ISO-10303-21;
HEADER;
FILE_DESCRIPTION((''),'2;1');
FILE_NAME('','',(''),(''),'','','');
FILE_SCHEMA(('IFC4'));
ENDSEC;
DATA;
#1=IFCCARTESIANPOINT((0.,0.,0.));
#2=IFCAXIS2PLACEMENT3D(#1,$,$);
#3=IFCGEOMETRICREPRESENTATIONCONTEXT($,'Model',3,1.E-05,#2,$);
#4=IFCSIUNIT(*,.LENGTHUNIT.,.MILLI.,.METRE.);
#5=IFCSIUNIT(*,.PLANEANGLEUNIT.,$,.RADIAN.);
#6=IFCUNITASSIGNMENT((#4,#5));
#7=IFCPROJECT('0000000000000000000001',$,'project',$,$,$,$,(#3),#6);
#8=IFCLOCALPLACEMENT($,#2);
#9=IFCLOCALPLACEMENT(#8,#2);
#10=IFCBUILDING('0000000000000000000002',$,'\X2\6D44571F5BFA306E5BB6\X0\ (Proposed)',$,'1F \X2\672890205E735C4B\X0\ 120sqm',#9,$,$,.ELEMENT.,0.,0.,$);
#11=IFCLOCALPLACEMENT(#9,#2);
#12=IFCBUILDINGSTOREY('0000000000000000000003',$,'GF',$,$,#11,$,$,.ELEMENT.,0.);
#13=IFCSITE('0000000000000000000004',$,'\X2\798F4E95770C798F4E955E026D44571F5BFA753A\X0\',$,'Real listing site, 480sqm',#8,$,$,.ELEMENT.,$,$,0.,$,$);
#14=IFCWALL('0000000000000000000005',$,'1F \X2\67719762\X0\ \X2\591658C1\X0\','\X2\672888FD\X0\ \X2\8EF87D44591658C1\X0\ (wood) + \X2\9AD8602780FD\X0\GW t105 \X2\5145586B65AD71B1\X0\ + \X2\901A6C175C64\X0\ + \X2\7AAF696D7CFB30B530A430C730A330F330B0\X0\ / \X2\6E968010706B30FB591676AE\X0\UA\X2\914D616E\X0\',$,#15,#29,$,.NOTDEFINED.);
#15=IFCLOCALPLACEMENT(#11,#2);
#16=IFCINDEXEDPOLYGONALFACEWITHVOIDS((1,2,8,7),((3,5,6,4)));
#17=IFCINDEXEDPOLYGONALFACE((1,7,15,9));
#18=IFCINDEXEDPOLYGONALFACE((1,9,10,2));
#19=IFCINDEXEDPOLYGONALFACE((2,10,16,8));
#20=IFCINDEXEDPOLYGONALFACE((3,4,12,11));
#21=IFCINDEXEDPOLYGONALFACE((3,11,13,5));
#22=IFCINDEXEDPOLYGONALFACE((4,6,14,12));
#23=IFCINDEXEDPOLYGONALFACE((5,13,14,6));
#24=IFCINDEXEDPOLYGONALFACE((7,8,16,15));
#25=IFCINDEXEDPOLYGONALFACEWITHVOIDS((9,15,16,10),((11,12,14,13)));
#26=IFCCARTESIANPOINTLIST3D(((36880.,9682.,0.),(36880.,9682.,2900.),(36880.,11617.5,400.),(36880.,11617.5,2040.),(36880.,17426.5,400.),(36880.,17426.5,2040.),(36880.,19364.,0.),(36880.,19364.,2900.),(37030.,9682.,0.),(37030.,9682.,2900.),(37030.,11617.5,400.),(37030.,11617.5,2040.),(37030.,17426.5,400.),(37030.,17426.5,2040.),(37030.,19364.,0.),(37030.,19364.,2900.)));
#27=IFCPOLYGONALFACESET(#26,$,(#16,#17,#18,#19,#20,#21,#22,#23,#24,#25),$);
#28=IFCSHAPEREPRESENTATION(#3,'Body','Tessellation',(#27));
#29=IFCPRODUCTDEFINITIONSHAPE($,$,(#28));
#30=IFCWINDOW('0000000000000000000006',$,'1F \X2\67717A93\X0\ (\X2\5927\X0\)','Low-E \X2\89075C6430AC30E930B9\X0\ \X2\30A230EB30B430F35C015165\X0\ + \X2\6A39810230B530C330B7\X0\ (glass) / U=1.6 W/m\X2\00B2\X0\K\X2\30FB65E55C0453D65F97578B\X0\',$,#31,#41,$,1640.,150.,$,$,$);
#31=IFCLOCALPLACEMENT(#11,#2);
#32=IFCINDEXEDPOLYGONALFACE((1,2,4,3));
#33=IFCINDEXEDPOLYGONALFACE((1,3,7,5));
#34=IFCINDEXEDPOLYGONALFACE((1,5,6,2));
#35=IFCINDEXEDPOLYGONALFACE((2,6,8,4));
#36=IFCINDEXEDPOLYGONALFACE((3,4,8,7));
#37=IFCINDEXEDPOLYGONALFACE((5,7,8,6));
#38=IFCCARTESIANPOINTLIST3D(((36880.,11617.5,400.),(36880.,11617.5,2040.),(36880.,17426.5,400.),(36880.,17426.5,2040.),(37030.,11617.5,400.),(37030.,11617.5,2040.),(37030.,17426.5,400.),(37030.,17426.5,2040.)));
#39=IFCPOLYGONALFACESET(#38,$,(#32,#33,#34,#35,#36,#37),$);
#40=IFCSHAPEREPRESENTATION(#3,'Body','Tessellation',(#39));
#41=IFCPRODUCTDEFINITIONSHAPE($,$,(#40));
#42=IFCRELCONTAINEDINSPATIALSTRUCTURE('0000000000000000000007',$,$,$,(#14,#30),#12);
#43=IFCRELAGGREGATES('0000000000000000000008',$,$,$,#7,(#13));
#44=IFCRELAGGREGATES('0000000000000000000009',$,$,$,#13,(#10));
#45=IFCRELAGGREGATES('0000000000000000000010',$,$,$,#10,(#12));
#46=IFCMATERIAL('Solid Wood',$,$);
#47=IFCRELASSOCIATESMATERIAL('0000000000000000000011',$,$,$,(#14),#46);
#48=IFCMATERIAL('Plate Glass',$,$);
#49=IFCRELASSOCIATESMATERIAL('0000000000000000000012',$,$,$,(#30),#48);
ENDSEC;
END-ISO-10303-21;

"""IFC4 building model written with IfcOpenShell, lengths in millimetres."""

from ifc_helpers import new_model, si_unit, frame, frame_2d, origin, place, context, project, spatial, rectangle, extrude, material, element, fill, save


model = new_model("IFC4")

# Units and contexts
model_context = context("Model", 3, precision=1e-05, world=origin())
ifc_project = project(units=[si_unit("LENGTHUNIT", "METRE", prefix="MILLI"), si_unit("PLANEANGLEUNIT", "RADIAN")], contexts=[model_context])

# Site, building, storey
site_placement = place(None, origin())
site = spatial("IfcSite", under=ifc_project, at=site_placement, Name="福井県福井市浄土寺町", ObjectType="Real listing site, 480sqm", CompositionType="ELEMENT", RefElevation=0.0)
building_placement = place(site_placement, origin())
building = spatial("IfcBuilding", under=site, at=building_placement, Name="浄土寺の家 (Proposed)", ObjectType="1F 木造平屋 120sqm", CompositionType="ELEMENT", ElevationOfRefHeight=0.0, ElevationOfTerrain=0.0)
storey_placement = place(building_placement, origin())
storey = spatial("IfcBuildingStorey", under=building, at=storey_placement, Name="GF", CompositionType="ELEMENT", Elevation=0.0)

# Shared definitions
ifc_material_1 = material(Name="Solid Wood")

# Wall, opening, window
wall_1_placement = place(storey_placement, frame((18440.0, 4841.0, 0.0)))
wall_1 = element("IfcWall", 1, at=wall_1_placement, inside=storey, material=ifc_material_1, Name="1F 東面 外壁", Description="木製 軸組外壁 (wood) + 高性能GW t105 充填断熱 + 通気層 + 窯業系サイディング / 準耐火・外皮UA配慮", PredefinedType="NOTDEFINED", context=model_context, shape_type="SweptSolid", body=[
    extrude(rectangle(XDim=150.0, YDim=9682.0, at=frame_2d((75.0, 4841.0))), frame((18440.0, 4841.0, 0.0)), (0.0, 0.0, 1.0), 2900.0),
])
opening_placement = place(storey_placement, frame((18440.0, 5809.0, 200.0)))
opening = element("IfcOpeningElement", 2, at=opening_placement, cuts=wall_1, PredefinedType="NOTDEFINED", context=model_context, shape_type="SweptSolid", body=[
    extrude(rectangle(XDim=150.0, YDim=5809.0, at=frame_2d((75.0, 2904.0))), frame((18440.0, 5809.0, 200.0)), (0.0, 0.0, 1.0), 1640.0),
])
ifc_material_2 = material(Name="Plate Glass")
window_placement = place(storey_placement, frame((18440.0, 5809.0, 200.0)))
window = element("IfcWindow", 3, at=window_placement, inside=storey, material=ifc_material_2, Name="1F 東窓 (大)", Description="Low-E 複層ガラス アルゴン封入 + 樹脂サッシ (glass) / U=1.6 W/m²K・日射取得型", OverallHeight=1640.0, OverallWidth=150.0, context=model_context, shape_type="SweptSolid", body=[
    extrude(rectangle(XDim=150.0, YDim=5809.0, at=frame_2d((75.0, 2904.0))), frame((18440.0, 5809.0, 200.0)), (0.0, 0.0, 1.0), 1640.0),
])
fill(opening, window)

save(model, "model.ifc")
